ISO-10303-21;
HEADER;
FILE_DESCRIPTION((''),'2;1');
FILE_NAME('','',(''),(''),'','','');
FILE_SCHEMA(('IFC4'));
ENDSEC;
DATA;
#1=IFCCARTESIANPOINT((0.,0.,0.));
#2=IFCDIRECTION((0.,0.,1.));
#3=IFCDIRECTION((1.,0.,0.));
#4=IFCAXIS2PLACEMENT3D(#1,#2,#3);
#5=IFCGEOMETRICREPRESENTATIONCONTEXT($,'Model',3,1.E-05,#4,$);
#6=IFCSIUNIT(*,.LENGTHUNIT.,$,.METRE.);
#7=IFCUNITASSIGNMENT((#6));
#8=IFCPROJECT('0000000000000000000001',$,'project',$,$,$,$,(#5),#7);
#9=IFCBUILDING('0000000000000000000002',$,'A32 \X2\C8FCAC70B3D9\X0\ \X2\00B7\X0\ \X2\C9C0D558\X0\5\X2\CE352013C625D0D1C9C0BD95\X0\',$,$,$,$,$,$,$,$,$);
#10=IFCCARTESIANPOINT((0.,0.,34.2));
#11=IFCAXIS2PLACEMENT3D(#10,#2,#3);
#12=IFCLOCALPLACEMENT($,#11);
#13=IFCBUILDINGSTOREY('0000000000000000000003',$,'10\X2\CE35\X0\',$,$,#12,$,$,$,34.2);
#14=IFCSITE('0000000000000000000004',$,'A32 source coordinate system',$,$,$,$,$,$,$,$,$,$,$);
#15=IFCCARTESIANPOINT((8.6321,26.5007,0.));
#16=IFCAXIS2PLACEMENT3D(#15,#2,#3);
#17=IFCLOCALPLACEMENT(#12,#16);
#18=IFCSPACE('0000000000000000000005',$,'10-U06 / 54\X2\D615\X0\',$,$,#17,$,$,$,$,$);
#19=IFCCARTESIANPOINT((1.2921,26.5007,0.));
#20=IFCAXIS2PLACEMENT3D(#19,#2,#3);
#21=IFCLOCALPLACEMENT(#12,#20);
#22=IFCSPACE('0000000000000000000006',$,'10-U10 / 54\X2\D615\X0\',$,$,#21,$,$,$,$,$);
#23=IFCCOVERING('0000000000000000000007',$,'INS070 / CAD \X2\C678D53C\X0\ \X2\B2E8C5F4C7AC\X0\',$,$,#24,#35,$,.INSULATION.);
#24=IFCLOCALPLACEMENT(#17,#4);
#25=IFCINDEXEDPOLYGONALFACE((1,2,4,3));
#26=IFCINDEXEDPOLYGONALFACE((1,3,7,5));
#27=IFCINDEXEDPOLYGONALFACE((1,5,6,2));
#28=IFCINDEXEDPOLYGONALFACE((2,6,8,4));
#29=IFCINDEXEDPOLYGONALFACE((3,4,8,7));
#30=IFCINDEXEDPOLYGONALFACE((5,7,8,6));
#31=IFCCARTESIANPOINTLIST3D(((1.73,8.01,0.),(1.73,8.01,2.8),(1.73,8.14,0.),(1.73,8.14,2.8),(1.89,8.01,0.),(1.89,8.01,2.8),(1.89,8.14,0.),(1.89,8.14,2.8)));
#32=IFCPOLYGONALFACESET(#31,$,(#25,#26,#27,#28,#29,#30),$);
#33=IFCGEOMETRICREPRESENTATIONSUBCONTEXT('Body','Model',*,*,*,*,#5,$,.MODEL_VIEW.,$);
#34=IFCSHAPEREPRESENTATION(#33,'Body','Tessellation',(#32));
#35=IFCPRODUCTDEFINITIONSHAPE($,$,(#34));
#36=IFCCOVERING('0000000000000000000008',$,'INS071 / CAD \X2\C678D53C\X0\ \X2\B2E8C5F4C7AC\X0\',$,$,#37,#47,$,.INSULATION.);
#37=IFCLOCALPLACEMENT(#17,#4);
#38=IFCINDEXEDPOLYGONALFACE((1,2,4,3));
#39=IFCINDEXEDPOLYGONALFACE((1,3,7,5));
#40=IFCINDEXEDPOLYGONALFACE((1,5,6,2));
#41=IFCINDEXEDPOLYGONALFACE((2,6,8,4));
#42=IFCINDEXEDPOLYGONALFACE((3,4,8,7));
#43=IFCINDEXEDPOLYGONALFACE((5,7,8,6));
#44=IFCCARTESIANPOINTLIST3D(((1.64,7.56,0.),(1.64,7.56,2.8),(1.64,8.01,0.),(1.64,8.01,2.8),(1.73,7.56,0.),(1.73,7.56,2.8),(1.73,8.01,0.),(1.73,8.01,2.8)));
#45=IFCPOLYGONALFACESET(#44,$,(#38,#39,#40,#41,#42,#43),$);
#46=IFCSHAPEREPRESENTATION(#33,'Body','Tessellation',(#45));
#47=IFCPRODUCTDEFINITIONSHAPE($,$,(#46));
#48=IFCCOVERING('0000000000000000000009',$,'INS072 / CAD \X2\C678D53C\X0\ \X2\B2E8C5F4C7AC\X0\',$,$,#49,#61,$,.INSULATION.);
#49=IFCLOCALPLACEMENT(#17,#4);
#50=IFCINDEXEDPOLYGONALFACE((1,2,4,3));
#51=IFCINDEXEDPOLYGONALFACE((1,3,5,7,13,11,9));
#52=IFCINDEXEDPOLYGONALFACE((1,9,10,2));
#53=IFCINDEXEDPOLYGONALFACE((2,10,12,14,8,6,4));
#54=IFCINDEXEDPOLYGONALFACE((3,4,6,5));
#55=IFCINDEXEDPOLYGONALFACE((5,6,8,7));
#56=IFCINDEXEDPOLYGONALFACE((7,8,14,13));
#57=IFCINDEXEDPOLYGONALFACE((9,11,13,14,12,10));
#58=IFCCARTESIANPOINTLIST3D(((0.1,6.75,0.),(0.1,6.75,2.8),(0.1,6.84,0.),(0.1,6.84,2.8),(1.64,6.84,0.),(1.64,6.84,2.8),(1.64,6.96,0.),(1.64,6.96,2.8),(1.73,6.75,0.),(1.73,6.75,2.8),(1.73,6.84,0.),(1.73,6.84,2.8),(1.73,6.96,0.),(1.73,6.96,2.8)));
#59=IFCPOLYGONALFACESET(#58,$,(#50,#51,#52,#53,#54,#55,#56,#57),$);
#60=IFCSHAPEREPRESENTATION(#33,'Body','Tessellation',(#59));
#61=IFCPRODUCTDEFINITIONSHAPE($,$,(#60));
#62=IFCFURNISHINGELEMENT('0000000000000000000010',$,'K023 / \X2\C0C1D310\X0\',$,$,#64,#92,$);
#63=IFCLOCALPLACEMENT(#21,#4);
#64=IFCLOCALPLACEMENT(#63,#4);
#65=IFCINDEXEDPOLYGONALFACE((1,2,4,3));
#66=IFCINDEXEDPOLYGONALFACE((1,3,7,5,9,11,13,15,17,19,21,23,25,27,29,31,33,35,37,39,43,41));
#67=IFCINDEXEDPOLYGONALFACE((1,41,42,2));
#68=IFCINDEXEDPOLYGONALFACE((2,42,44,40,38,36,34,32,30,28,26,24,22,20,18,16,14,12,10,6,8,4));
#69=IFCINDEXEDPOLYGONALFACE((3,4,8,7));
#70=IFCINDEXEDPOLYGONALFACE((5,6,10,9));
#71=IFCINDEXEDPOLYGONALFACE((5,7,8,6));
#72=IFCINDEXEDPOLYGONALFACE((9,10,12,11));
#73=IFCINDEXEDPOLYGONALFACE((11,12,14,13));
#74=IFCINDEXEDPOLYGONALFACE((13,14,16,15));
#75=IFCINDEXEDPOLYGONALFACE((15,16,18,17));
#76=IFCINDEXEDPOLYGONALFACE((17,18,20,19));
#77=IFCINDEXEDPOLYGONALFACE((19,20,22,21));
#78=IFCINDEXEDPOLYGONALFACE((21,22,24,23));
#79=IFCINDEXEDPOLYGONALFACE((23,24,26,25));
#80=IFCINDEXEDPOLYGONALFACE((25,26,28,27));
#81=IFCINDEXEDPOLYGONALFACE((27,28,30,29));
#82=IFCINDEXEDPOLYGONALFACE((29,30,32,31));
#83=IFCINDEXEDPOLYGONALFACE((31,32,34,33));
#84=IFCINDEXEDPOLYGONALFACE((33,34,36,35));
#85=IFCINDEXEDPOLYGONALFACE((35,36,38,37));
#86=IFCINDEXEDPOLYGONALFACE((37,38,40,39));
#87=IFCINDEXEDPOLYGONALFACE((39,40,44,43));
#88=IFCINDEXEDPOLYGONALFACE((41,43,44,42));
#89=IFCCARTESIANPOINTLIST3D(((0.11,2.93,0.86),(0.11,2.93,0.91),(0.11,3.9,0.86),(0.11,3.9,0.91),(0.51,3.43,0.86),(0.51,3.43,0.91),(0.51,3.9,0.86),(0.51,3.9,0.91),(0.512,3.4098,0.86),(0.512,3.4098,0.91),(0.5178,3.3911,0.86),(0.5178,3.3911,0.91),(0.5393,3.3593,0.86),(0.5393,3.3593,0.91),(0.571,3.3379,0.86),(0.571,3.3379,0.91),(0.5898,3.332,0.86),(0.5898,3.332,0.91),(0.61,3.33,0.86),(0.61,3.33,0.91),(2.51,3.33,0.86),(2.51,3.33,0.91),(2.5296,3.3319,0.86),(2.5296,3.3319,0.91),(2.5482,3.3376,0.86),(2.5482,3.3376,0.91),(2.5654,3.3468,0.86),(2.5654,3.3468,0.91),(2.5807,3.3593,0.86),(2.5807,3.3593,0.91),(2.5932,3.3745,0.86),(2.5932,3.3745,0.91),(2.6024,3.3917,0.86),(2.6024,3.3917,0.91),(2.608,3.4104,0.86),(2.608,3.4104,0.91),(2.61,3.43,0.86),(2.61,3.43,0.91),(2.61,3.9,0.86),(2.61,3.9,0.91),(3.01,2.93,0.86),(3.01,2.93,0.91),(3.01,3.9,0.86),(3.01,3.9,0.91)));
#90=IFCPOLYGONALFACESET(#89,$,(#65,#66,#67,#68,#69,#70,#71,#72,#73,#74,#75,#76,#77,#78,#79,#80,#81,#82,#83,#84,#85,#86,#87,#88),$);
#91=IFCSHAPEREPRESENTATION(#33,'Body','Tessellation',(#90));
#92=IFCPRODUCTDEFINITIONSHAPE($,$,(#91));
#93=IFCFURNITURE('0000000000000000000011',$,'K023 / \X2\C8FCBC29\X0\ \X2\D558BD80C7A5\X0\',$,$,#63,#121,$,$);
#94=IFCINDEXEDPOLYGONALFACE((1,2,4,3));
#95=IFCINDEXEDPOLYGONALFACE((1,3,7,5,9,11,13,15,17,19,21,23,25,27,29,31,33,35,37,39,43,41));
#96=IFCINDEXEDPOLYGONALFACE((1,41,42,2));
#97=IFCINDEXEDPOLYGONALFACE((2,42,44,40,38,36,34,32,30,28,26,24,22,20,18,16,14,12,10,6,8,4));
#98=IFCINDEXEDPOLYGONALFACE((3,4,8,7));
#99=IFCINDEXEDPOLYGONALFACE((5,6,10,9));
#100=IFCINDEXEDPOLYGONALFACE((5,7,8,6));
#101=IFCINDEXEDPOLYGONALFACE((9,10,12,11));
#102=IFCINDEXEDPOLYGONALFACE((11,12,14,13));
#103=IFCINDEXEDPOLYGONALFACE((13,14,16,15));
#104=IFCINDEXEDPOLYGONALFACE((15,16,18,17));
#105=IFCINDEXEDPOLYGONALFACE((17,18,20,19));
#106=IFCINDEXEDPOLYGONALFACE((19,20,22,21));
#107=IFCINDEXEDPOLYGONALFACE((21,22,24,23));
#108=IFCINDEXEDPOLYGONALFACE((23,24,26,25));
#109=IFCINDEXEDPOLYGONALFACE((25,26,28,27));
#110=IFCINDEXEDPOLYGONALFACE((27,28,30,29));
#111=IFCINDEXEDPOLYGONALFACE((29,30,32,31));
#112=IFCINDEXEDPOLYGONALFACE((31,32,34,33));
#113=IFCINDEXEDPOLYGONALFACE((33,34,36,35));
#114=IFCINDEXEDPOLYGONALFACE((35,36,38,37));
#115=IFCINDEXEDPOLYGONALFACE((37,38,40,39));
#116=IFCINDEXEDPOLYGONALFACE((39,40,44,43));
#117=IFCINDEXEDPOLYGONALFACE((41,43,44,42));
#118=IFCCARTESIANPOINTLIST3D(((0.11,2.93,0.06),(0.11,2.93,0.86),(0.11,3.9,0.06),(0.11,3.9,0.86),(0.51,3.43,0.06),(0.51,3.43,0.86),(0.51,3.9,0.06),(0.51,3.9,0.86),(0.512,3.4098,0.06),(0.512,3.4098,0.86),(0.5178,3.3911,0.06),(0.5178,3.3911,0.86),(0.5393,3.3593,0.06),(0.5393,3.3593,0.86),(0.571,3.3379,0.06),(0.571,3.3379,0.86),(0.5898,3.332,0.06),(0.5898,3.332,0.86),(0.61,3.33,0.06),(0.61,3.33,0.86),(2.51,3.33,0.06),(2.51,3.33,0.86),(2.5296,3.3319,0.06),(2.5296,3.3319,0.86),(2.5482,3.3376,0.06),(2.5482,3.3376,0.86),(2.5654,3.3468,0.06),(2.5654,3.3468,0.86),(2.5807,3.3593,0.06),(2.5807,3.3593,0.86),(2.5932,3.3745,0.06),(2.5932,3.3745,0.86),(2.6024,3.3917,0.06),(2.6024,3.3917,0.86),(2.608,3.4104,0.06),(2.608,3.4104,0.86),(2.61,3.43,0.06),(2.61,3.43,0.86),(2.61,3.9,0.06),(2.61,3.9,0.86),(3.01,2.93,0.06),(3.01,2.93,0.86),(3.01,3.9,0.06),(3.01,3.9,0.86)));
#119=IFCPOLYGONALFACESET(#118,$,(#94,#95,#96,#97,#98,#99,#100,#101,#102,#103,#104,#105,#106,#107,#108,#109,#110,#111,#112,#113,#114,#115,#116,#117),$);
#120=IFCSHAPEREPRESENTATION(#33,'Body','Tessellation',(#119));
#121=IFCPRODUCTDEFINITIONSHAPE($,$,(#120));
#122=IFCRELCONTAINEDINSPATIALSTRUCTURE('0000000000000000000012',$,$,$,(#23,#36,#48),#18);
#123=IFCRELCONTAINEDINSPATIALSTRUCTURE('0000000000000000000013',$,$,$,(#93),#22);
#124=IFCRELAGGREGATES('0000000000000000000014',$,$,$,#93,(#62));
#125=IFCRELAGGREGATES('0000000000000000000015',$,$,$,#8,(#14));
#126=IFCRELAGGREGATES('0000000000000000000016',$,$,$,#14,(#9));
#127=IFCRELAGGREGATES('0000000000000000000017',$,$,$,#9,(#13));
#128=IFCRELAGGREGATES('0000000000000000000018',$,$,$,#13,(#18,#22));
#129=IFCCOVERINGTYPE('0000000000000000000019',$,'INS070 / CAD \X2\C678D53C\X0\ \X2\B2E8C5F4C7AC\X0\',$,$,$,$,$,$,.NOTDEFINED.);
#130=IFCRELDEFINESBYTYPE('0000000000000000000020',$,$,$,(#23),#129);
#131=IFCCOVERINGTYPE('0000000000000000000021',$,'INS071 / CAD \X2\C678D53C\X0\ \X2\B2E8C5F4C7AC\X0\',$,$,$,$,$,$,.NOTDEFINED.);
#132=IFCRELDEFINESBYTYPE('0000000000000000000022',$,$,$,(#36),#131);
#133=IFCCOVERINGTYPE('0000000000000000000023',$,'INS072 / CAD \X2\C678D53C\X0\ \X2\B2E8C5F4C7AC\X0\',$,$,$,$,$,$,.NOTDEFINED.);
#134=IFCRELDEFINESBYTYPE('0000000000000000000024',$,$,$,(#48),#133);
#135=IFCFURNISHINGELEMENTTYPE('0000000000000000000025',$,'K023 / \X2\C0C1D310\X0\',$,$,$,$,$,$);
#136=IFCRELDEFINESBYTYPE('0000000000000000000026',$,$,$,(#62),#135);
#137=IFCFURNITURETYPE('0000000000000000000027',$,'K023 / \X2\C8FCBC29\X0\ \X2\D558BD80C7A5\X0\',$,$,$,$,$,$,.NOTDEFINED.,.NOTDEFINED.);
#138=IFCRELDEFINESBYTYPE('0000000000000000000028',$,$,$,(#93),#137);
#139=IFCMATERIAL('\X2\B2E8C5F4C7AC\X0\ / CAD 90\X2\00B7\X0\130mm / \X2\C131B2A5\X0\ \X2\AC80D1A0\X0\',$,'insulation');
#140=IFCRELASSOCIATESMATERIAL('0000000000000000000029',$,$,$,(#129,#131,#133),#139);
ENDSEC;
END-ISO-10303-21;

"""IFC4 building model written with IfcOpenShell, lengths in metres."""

from ifc_helpers import new_model, si_unit, frame, origin, origin_with_axes, place, context, subcontext, project, spatial, polyline, outline, extrude, source, transform, mapped, material, type_object, type_shapes, element, aggregate, save


model = new_model("IFC4")

# Units and contexts
model_context = context("Model", 3, precision=1e-05, world=origin_with_axes())
body_context = subcontext(model_context, "Body", "Model", "MODEL_VIEW")
ifc_project = project(units=[si_unit("LENGTHUNIT", "METRE")], contexts=[model_context])

# Site, building, storey, space
storey_placement = place(None, frame((0.0, 0.0, 34.2), z_axis=(0.0, 0.0, 1.0), x_axis=(1.0, 0.0, 0.0)))
space_1_placement = place(storey_placement, frame((8.6321, 26.5007, 0.0), z_axis=(0.0, 0.0, 1.0), x_axis=(1.0, 0.0, 0.0)))
site = spatial("IfcSite", under=ifc_project, Name="A32 source coordinate system")
building = spatial("IfcBuilding", under=site, Name="A32 주거동 · 지하5층–옥탑지붕")
storey = spatial("IfcBuildingStorey", under=building, at=storey_placement, Name="10층", Elevation=34.2)
space_1 = spatial("IfcSpace", under=storey, at=space_1_placement, Name="10-U06 / 54형")

# Coverings
ifc_material = material(Name="단열재 / CAD 90·130mm / 성능 검토", Category="insulation")
covering_type_1 = type_object("IfcCoveringType", Name="INS070 / CAD 외피 단열재", PredefinedType="NOTDEFINED", material=ifc_material)
shared_shape_1 = source(origin(), body_context, "Body", "SweptSolid", [
    extrude(outline(polyline([(1.73, 8.14), (1.89, 8.14), (1.89, 8.01), (1.73, 8.01), (1.73, 8.14)])), origin(), (0.0, 0.0, 1.0), 2.8),
])
type_shapes(covering_type_1, [shared_shape_1])
covering_1_placement = place(space_1_placement, origin_with_axes())
element("IfcCovering", 1, at=covering_1_placement, inside=space_1, type_object=covering_type_1, Name="INS070 / CAD 외피 단열재", PredefinedType="INSULATION", context=body_context, shape_type="MappedRepresentation", body=[
    mapped(shared_shape_1, transform((0.0, 0.0, 0.0), scale=1.0)),
])
covering_type_2 = type_object("IfcCoveringType", Name="INS071 / CAD 외피 단열재", PredefinedType="NOTDEFINED", material=ifc_material)
shared_shape_2 = source(origin(), body_context, "Body", "SweptSolid", [
    extrude(outline(polyline([(1.73, 7.56), (1.64, 7.56), (1.64, 8.01), (1.73, 8.01), (1.73, 7.56)])), origin(), (0.0, 0.0, 1.0), 2.8),
])
type_shapes(covering_type_2, [shared_shape_2])
covering_2_placement = place(space_1_placement, origin_with_axes())
element("IfcCovering", 2, at=covering_2_placement, inside=space_1, type_object=covering_type_2, Name="INS071 / CAD 외피 단열재", PredefinedType="INSULATION", context=body_context, shape_type="MappedRepresentation", body=[
    mapped(shared_shape_2, transform((0.0, 0.0, 0.0), scale=1.0)),
])
covering_type_3 = type_object("IfcCoveringType", Name="INS072 / CAD 외피 단열재", PredefinedType="NOTDEFINED", material=ifc_material)
shared_shape_3 = source(origin(), body_context, "Body", "SweptSolid", [
    extrude(outline(polyline([(1.64, 6.84), (1.64, 6.96), (1.73, 6.96), (1.73, 6.84), (1.73, 6.75), (0.1, 6.75), (0.1, 6.84), (1.64, 6.84)])), origin(), (0.0, 0.0, 1.0), 2.8),
])
type_shapes(covering_type_3, [shared_shape_3])
covering_3_placement = place(space_1_placement, origin_with_axes())
element("IfcCovering", 3, at=covering_3_placement, inside=space_1, type_object=covering_type_3, Name="INS072 / CAD 외피 단열재", PredefinedType="INSULATION", context=body_context, shape_type="MappedRepresentation", body=[
    mapped(shared_shape_3, transform((0.0, 0.0, 0.0), scale=1.0)),
])

# Shared definitions
space_2_placement = place(storey_placement, frame((1.2921, 26.5007, 0.0), z_axis=(0.0, 0.0, 1.0), x_axis=(1.0, 0.0, 0.0)))

# Furnishing element
furnishing_element_type_1 = type_object("IfcFurnishingElementType", Name="K023 / 상판")
shared_shape_4 = source(origin(), body_context, "Body", "SweptSolid", [
    extrude(outline(polyline([(0.51, 3.43), (0.512, 3.4098), (0.5178, 3.3911), (0.5393, 3.3593), (0.571, 3.3379), (0.5898, 3.332), (0.61, 3.33), (2.51, 3.33), (2.5296, 3.3319), (2.5482, 3.3376), (2.5654, 3.3468), (2.5807, 3.3593), (2.5932, 3.3745), (2.6024, 3.3917), (2.608, 3.4104), (2.61, 3.43), (2.61, 3.9), (3.01, 3.9), (3.01, 2.93), (0.11, 2.93), (0.11, 3.9), (0.51, 3.9), (0.51, 3.43)])), frame((0.0, 0.0, 0.86)), (0.0, 0.0, 1.0), 0.05),
])
type_shapes(furnishing_element_type_1, [shared_shape_4])
furniture_1_placement = place(space_2_placement, origin_with_axes())
furnishing_1_placement = place(furniture_1_placement, origin_with_axes())
furnishing_1 = element("IfcFurnishingElement", 4, at=furnishing_1_placement, type_object=furnishing_element_type_1, Name="K023 / 상판", context=body_context, shape_type="MappedRepresentation", body=[
    mapped(shared_shape_4, transform((0.0, 0.0, 0.0), scale=1.0)),
])

# Shared definitions
space_2 = spatial("IfcSpace", under=storey, at=space_2_placement, Name="10-U10 / 54형")

# Furniture
furniture_type_1 = type_object("IfcFurnitureType", Name="K023 / 주방 하부장", AssemblyPlace="NOTDEFINED", PredefinedType="NOTDEFINED")
shared_shape_5 = source(origin(), body_context, "Body", "SweptSolid", [
    extrude(outline(polyline([(0.51, 3.9), (0.51, 3.43), (0.512, 3.4098), (0.5178, 3.3911), (0.5393, 3.3593), (0.571, 3.3379), (0.5898, 3.332), (0.61, 3.33), (2.51, 3.33), (2.5296, 3.3319), (2.5482, 3.3376), (2.5654, 3.3468), (2.5807, 3.3593), (2.5932, 3.3745), (2.6024, 3.3917), (2.608, 3.4104), (2.61, 3.43), (2.61, 3.9), (3.01, 3.9), (3.01, 2.93), (0.11, 2.93), (0.11, 3.9), (0.51, 3.9)])), frame((0.0, 0.0, 0.06)), (0.0, 0.0, 1.0), 0.8),
])
type_shapes(furniture_type_1, [shared_shape_5])
furniture_1 = element("IfcFurniture", 5, at=furniture_1_placement, inside=space_2, type_object=furniture_type_1, Name="K023 / 주방 하부장", context=body_context, shape_type="MappedRepresentation", body=[
    mapped(shared_shape_5, transform((0.0, 0.0, 0.0), scale=1.0)),
])
aggregate(furniture_1, [furnishing_1])

save(model, "model.ifc")
